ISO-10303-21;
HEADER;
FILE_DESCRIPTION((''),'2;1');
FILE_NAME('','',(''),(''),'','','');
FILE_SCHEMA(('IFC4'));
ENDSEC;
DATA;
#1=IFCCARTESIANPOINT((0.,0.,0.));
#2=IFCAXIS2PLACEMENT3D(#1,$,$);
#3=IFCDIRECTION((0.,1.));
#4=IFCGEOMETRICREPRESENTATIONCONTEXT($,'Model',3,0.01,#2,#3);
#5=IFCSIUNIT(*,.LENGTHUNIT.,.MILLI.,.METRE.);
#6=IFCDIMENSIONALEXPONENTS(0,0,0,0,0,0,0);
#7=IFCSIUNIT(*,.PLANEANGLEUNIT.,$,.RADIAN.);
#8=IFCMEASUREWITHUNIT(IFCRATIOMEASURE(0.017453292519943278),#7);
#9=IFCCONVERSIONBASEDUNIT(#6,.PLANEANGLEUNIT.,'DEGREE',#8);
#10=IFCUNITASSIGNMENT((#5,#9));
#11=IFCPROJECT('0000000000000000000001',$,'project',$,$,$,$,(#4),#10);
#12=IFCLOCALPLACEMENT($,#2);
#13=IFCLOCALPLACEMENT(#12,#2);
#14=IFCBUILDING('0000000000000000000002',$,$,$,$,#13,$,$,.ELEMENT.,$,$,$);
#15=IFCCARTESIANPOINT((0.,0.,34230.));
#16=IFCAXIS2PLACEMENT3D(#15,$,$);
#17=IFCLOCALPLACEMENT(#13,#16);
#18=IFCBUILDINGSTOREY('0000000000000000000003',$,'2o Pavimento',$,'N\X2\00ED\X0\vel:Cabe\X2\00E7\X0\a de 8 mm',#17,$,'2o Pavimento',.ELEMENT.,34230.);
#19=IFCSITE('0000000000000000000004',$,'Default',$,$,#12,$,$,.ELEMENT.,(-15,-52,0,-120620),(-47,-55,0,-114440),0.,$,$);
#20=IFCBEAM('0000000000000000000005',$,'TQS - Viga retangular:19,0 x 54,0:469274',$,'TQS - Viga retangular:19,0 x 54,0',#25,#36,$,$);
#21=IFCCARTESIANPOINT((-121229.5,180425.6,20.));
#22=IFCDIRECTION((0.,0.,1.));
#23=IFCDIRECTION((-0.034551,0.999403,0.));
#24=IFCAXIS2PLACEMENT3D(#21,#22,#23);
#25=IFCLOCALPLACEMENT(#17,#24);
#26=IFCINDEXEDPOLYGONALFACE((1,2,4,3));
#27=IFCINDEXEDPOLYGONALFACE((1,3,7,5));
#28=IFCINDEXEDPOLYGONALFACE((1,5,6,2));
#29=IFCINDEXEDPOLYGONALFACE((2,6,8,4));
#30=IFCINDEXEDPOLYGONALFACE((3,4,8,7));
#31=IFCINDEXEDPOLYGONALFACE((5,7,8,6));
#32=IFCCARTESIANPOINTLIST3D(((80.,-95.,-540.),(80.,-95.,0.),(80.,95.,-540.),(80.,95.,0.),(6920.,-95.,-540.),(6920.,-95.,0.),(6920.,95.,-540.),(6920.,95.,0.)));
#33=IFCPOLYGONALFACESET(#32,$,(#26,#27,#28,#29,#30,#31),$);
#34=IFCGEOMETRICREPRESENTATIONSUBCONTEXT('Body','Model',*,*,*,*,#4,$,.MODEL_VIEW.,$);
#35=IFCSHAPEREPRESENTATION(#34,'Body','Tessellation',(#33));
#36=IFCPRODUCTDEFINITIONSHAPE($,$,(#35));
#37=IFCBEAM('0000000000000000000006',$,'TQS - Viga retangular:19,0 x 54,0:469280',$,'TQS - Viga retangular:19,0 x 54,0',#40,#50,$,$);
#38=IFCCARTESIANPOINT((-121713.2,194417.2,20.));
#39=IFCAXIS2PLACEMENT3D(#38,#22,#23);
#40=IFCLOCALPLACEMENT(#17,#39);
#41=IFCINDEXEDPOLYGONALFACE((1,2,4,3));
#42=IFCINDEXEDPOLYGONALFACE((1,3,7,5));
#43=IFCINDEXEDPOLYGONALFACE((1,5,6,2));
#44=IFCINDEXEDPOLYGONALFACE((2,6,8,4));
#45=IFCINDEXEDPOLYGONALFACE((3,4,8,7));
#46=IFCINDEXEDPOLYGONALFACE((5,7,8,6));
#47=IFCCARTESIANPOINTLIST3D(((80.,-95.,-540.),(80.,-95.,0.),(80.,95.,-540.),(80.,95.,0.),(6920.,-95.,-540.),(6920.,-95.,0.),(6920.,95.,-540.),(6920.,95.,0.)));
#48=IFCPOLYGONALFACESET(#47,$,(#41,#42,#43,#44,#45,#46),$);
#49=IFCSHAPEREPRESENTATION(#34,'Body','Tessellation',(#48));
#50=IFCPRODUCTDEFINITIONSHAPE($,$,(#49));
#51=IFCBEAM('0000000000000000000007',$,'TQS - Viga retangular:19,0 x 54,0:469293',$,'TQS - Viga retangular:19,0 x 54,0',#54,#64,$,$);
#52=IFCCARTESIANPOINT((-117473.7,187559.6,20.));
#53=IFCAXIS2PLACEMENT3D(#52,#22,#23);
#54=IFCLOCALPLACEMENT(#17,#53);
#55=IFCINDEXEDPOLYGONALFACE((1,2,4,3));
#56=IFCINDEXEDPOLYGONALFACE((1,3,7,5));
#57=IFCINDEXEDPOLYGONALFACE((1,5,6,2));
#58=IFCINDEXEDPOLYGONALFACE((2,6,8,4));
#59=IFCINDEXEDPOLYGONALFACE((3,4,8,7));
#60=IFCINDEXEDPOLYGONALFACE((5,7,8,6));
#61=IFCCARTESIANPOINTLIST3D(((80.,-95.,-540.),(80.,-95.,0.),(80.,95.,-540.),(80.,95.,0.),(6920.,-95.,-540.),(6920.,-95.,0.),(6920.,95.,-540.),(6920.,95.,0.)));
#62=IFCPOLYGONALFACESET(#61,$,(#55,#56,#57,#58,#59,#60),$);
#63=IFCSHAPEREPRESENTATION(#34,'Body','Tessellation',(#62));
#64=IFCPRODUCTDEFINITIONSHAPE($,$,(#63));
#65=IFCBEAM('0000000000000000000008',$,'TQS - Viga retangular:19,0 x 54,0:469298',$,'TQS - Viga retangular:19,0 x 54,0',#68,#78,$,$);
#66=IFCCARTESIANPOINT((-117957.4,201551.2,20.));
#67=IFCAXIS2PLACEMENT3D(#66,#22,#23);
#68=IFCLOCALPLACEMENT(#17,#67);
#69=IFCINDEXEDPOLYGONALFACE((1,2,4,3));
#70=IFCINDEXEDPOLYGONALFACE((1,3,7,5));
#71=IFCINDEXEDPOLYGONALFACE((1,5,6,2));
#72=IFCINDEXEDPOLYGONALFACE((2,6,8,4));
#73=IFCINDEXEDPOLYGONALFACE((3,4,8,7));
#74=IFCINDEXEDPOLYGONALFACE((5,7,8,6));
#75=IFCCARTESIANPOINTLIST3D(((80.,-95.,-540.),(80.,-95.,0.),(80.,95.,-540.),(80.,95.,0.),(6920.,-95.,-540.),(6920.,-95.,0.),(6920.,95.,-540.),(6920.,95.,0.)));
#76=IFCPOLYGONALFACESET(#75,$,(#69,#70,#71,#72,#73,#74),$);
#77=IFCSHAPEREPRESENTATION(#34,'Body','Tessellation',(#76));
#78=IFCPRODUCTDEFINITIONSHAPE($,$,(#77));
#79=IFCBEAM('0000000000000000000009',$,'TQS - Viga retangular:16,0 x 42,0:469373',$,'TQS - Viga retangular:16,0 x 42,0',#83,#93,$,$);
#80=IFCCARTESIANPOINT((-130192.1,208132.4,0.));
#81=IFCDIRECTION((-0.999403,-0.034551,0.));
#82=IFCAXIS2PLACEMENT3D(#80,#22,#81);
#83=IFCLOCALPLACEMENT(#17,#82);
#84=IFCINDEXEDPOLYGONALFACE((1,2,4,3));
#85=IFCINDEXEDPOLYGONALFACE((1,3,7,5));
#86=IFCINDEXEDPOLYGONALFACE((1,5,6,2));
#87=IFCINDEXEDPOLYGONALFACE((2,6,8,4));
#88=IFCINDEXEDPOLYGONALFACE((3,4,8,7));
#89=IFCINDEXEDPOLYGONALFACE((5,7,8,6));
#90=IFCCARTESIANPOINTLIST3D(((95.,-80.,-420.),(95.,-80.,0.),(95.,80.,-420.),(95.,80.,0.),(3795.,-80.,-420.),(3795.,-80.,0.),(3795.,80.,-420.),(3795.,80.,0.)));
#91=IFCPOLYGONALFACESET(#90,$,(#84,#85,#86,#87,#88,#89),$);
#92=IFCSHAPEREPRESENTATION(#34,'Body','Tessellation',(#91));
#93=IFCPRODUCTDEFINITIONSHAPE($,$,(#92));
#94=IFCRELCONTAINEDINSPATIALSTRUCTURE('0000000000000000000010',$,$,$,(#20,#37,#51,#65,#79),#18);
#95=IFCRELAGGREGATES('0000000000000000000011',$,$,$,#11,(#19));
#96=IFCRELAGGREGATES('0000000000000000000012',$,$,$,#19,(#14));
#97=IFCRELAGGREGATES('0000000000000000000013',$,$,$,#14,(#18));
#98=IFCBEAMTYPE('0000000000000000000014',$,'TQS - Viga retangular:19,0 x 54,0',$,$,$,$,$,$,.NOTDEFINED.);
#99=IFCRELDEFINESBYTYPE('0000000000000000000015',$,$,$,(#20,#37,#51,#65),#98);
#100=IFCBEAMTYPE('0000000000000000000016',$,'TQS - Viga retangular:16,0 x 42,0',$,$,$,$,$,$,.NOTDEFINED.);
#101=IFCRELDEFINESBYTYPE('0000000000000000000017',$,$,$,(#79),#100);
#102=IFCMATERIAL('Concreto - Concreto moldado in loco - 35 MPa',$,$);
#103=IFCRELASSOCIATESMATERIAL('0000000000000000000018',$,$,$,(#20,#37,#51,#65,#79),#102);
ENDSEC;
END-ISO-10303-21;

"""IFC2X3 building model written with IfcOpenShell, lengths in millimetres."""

from ifc_helpers import new_model, entity, si_unit, converted_unit, direction, frame, frame_2d, origin, place, context, subcontext, project, spatial, rectangle, extrude, material, type_object, element, save


model = new_model("IFC2X3")

# Units and contexts
model_context = context("Model", 3, precision=0.01, world=origin(), true_north=direction((0.0, 1.0)))
body_context = subcontext(model_context, "Body", "Model", "MODEL_VIEW")
ifc_project = project(units=[si_unit("LENGTHUNIT", "METRE", prefix="MILLI"), converted_unit("PLANEANGLEUNIT", "DEGREE", entity("IfcRatioMeasure", 0.017453292519943278), si_unit("PLANEANGLEUNIT", "RADIAN"), dimensions=[0, 0, 0, 0, 0, 0, 0])], contexts=[model_context])

# Site, building, storey
site_placement = place(None, origin())
site = spatial("IfcSite", under=ifc_project, at=site_placement, Name="Default", CompositionType="ELEMENT", RefLatitude=(-15, -52, 0, -120620), RefLongitude=(-47, -55, 0, -114440), RefElevation=0.0)
building_placement = place(site_placement, origin())
building = spatial("IfcBuilding", under=site, at=building_placement, CompositionType="ELEMENT")
storey_placement = place(building_placement, frame((0.0, 0.0, 34230.0)))
storey = spatial("IfcBuildingStorey", under=building, at=storey_placement, Name="2o Pavimento", ObjectType="Nível:Cabeça de 8 mm", LongName="2o Pavimento", CompositionType="ELEMENT", Elevation=34230.0)

# Beams
ifc_material = material(Name="Concreto - Concreto moldado in loco - 35 MPa")
beam_type_1 = type_object("IfcBeamType", Name="TQS - Viga retangular:19,0 x 54,0", PredefinedType="NOTDEFINED")
beam_1_placement = place(storey_placement, frame((-121229.5, 180425.6, 20.0), z_axis=(0.0, 0.0, 1.0), x_axis=(-0.034551, 0.999403, 0.0)))
element("IfcBeam", 1, at=beam_1_placement, inside=storey, type_object=beam_type_1, material=ifc_material, Name="TQS - Viga retangular:19,0 x 54,0:469274", ObjectType="TQS - Viga retangular:19,0 x 54,0", context=body_context, shape_type="SweptSolid", body=[
    extrude(rectangle(XDim=540.0, YDim=190.0, at=frame_2d((0.0, 0.0), x_axis=(1.0, 0.0))), frame((80.0, 0.0, -270.0), z_axis=(1.0, 0.0, 0.0), x_axis=(0.0, 0.0, -1.0)), (0.0, 0.0, 1.0), 6840.0),
])
beam_2_placement = place(storey_placement, frame((-121713.2, 194417.2, 20.0), z_axis=(0.0, 0.0, 1.0), x_axis=(-0.034551, 0.999403, 0.0)))
element("IfcBeam", 2, at=beam_2_placement, inside=storey, type_object=beam_type_1, material=ifc_material, Name="TQS - Viga retangular:19,0 x 54,0:469280", ObjectType="TQS - Viga retangular:19,0 x 54,0", context=body_context, shape_type="SweptSolid", body=[
    extrude(rectangle(XDim=540.0, YDim=190.0, at=frame_2d((0.0, 0.0), x_axis=(1.0, 0.0))), frame((80.0, 0.0, -270.0), z_axis=(1.0, 0.0, 0.0), x_axis=(0.0, 0.0, -1.0)), (0.0, 0.0, 1.0), 6840.0),
])
beam_3_placement = place(storey_placement, frame((-117473.7, 187559.6, 20.0), z_axis=(0.0, 0.0, 1.0), x_axis=(-0.034551, 0.999403, 0.0)))
element("IfcBeam", 3, at=beam_3_placement, inside=storey, type_object=beam_type_1, material=ifc_material, Name="TQS - Viga retangular:19,0 x 54,0:469293", ObjectType="TQS - Viga retangular:19,0 x 54,0", context=body_context, shape_type="SweptSolid", body=[
    extrude(rectangle(XDim=540.0, YDim=190.0, at=frame_2d((0.0, 0.0), x_axis=(1.0, 0.0))), frame((80.0, 0.0, -270.0), z_axis=(1.0, 0.0, 0.0), x_axis=(0.0, 0.0, -1.0)), (0.0, 0.0, 1.0), 6840.0),
])
beam_4_placement = place(storey_placement, frame((-117957.4, 201551.2, 20.0), z_axis=(0.0, 0.0, 1.0), x_axis=(-0.034551, 0.999403, 0.0)))
element("IfcBeam", 4, at=beam_4_placement, inside=storey, type_object=beam_type_1, material=ifc_material, Name="TQS - Viga retangular:19,0 x 54,0:469298", ObjectType="TQS - Viga retangular:19,0 x 54,0", context=body_context, shape_type="SweptSolid", body=[
    extrude(rectangle(XDim=540.0, YDim=190.0, at=frame_2d((0.0, 0.0), x_axis=(1.0, 0.0))), frame((80.0, 0.0, -270.0), z_axis=(1.0, 0.0, 0.0), x_axis=(0.0, 0.0, -1.0)), (0.0, 0.0, 1.0), 6840.0),
])
beam_type_2 = type_object("IfcBeamType", Name="TQS - Viga retangular:16,0 x 42,0", PredefinedType="NOTDEFINED")
beam_5_placement = place(storey_placement, frame((-130192.1, 208132.4, 0.0), z_axis=(0.0, 0.0, 1.0), x_axis=(-0.999403, -0.034551, 0.0)))
element("IfcBeam", 5, at=beam_5_placement, inside=storey, type_object=beam_type_2, material=ifc_material, Name="TQS - Viga retangular:16,0 x 42,0:469373", ObjectType="TQS - Viga retangular:16,0 x 42,0", context=body_context, shape_type="SweptSolid", body=[
    extrude(rectangle(XDim=420.0, YDim=160.0, at=frame_2d((0.0, 0.0), x_axis=(1.0, 0.0))), frame((95.0, 0.0, -210.0), z_axis=(1.0, 0.0, 0.0), x_axis=(0.0, 0.0, -1.0)), (0.0, 0.0, 1.0), 3700.0),
])

save(model, "model.ifc")
